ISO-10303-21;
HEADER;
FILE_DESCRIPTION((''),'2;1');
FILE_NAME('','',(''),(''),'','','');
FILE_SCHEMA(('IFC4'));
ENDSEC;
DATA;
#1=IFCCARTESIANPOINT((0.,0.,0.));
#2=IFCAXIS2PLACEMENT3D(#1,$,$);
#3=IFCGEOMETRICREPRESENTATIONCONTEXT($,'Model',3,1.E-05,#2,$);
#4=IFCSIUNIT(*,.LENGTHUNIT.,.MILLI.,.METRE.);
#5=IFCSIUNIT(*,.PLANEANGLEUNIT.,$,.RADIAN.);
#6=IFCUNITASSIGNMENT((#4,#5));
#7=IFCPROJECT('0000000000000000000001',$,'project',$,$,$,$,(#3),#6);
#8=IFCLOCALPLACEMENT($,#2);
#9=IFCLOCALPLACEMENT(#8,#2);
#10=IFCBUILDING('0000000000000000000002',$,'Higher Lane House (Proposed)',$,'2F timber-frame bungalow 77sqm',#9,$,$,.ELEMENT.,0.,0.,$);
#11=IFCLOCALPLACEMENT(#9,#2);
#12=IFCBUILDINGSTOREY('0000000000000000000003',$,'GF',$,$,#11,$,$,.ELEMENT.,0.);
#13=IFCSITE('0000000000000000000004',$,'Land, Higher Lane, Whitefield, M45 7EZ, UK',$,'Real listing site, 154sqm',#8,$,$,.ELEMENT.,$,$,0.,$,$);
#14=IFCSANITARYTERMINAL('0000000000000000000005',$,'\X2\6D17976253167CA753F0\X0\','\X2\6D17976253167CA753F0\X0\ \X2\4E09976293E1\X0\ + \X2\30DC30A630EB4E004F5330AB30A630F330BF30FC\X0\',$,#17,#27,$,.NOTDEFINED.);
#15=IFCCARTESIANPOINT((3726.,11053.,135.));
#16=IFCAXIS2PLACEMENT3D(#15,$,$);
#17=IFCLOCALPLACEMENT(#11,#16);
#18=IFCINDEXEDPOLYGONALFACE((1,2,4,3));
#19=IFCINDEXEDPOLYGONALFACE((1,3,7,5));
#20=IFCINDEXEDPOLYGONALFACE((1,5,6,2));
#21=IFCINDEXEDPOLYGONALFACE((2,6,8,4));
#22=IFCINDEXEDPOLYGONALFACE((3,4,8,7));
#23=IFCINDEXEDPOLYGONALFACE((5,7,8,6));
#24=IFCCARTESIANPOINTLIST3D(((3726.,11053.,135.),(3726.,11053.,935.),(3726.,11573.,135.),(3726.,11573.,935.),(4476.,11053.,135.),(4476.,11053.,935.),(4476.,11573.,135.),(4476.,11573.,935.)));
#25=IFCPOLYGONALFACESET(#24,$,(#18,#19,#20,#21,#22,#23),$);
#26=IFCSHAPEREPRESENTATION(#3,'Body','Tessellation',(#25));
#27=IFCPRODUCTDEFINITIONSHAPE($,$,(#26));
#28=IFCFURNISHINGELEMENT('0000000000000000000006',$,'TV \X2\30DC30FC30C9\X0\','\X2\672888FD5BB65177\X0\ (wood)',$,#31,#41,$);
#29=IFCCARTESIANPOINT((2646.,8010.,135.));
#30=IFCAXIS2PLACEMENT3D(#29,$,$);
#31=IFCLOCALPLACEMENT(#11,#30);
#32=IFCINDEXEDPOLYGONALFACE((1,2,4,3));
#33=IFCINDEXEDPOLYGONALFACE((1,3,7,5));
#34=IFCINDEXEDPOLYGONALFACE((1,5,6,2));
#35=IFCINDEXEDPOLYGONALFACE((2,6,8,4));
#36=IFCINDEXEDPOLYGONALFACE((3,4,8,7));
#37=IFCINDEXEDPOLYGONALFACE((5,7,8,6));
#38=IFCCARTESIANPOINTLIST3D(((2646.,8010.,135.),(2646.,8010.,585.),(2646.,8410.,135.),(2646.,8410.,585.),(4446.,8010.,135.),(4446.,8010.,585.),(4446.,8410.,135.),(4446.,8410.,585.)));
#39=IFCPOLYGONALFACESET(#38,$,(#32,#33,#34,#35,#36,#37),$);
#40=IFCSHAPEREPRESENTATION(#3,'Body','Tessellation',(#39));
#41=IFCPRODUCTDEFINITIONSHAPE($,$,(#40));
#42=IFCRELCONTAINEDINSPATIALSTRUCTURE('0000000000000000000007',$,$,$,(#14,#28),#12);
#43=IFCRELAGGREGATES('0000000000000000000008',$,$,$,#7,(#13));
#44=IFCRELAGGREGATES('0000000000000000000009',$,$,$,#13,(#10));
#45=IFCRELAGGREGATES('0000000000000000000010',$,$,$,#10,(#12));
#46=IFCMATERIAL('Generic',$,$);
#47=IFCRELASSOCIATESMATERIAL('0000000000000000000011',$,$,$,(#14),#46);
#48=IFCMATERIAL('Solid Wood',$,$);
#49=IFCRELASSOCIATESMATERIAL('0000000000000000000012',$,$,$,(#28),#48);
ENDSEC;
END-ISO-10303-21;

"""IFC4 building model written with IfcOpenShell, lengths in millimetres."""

from ifc_helpers import new_model, si_unit, frame, frame_2d, origin, place, context, project, spatial, rectangle, extrude, material, element, save


model = new_model("IFC4")

# Units and contexts
model_context = context("Model", 3, precision=1e-05, world=origin())
ifc_project = project(units=[si_unit("LENGTHUNIT", "METRE", prefix="MILLI"), si_unit("PLANEANGLEUNIT", "RADIAN")], contexts=[model_context])

# Site, building, storey
site_placement = place(None, origin())
site = spatial("IfcSite", under=ifc_project, at=site_placement, Name="Land, Higher Lane, Whitefield, M45 7EZ, UK", ObjectType="Real listing site, 154sqm", CompositionType="ELEMENT", RefElevation=0.0)
building_placement = place(site_placement, origin())
building = spatial("IfcBuilding", under=site, at=building_placement, Name="Higher Lane House (Proposed)", ObjectType="2F timber-frame bungalow 77sqm", CompositionType="ELEMENT", ElevationOfRefHeight=0.0, ElevationOfTerrain=0.0)
storey_placement = place(building_placement, origin())
storey = spatial("IfcBuildingStorey", under=building, at=storey_placement, Name="GF", CompositionType="ELEMENT", Elevation=0.0)

# Shared definitions
ifc_material_1 = material(Name="Solid Wood")

# Shared definitions
ifc_material_2 = material(Name="Generic")

# Sanitary terminal
sanitary_terminal_1_placement = place(storey_placement, frame((3726.0, 11053.0, 135.0)))
element("IfcSanitaryTerminal", 1, at=sanitary_terminal_1_placement, inside=storey, material=ifc_material_2, Name="洗面化粧台", Description="洗面化粧台 三面鏡 + ボウル一体カウンター", PredefinedType="NOTDEFINED", context=model_context, shape_type="SweptSolid", body=[
    extrude(rectangle(XDim=750.0, YDim=520.0, at=frame_2d((375.0, 260.0))), frame((3726.0, 11053.0, 135.0)), (0.0, 0.0, 1.0), 800.0),
])

# Furnishing element
furnishing_placement = place(storey_placement, frame((2646.0, 8010.0, 135.0)))
element("IfcFurnishingElement", 2, at=furnishing_placement, inside=storey, material=ifc_material_1, Name="TV ボード", Description="木製家具 (wood)", context=model_context, shape_type="SweptSolid", body=[
    extrude(rectangle(XDim=1800.0, YDim=400.0, at=frame_2d((900.0, 200.0))), frame((2646.0, 8010.0, 135.0)), (0.0, 0.0, 1.0), 450.0),
])

save(model, "model.ifc")
